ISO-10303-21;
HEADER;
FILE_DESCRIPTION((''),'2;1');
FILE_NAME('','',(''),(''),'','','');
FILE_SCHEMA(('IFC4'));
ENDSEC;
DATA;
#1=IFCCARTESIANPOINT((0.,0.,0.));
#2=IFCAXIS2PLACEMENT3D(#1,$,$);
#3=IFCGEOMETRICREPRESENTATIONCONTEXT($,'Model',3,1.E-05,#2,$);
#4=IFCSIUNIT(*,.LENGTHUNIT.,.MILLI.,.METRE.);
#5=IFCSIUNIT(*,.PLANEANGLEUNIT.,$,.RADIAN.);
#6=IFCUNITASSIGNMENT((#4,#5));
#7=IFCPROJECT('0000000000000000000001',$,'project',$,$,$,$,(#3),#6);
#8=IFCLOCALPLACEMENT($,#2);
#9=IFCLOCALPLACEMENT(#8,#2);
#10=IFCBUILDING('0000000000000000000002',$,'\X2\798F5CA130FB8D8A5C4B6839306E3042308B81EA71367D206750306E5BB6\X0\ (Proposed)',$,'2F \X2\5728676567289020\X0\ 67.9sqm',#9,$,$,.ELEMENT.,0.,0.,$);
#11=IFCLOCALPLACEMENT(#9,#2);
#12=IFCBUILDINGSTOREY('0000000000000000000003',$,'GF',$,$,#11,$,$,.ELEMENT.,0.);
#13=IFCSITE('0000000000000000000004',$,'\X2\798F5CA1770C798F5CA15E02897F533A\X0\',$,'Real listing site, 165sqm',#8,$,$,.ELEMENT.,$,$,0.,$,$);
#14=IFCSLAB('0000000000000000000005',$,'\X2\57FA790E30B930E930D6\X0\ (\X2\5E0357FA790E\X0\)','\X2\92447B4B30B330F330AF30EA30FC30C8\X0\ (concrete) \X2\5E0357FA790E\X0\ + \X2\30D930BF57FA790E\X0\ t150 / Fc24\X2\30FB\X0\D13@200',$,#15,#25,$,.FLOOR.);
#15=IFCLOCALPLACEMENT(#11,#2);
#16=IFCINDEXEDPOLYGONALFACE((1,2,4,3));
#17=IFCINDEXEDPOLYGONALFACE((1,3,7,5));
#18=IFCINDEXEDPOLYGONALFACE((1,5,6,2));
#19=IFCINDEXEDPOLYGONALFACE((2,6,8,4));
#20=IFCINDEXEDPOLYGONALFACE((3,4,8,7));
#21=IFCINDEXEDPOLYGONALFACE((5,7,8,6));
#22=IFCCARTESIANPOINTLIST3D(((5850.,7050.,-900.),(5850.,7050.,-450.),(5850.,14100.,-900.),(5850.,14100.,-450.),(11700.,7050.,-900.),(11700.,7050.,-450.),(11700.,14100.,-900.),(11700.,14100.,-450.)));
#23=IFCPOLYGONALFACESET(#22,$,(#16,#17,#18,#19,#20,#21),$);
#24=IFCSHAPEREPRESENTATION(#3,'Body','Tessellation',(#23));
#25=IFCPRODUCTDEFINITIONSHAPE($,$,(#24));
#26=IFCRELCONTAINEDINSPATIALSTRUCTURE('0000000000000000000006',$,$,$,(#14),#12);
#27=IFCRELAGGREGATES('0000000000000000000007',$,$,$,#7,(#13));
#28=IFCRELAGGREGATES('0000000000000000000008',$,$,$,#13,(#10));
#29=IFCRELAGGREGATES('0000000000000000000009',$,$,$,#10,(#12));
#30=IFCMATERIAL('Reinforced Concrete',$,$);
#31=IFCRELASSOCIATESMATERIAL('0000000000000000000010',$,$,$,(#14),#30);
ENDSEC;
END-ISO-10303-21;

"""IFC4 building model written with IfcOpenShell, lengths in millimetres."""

from ifc_helpers import new_model, si_unit, frame, frame_2d, origin, place, context, project, spatial, rectangle, extrude, material, element, save


model = new_model("IFC4")

# Units and contexts
model_context = context("Model", 3, precision=1e-05, world=origin())
ifc_project = project(units=[si_unit("LENGTHUNIT", "METRE", prefix="MILLI"), si_unit("PLANEANGLEUNIT", "RADIAN")], contexts=[model_context])

# Site, building, storey
site_placement = place(None, origin())
site = spatial("IfcSite", under=ifc_project, at=site_placement, Name="福岡県福岡市西区", ObjectType="Real listing site, 165sqm", CompositionType="ELEMENT", RefElevation=0.0)
building_placement = place(site_placement, origin())
building = spatial("IfcBuilding", under=site, at=building_placement, Name="福岡・越屋根のある自然素材の家 (Proposed)", ObjectType="2F 在来木造 67.9sqm", CompositionType="ELEMENT", ElevationOfRefHeight=0.0, ElevationOfTerrain=0.0)
storey_placement = place(building_placement, origin())
storey = spatial("IfcBuildingStorey", under=building, at=storey_placement, Name="GF", CompositionType="ELEMENT", Elevation=0.0)

# Slab
ifc_material_1 = material(Name="Reinforced Concrete")
slab_1_placement = place(storey_placement, frame((2925.0, 3525.0, -450.0)))
element("IfcSlab", 1, at=slab_1_placement, inside=storey, material=ifc_material_1, Name="基礎スラブ (布基礎)", Description="鉄筋コンクリート (concrete) 布基礎 + ベタ基礎 t150 / Fc24・D13@200", PredefinedType="FLOOR", context=model_context, shape_type="SweptSolid", body=[
    extrude(rectangle(XDim=5850.0, YDim=7050.0, at=frame_2d((2925.0, 3525.0))), frame((2925.0, 3525.0, -450.0)), (0.0, 0.0, 1.0), 450.0),
])

save(model, "model.ifc")
